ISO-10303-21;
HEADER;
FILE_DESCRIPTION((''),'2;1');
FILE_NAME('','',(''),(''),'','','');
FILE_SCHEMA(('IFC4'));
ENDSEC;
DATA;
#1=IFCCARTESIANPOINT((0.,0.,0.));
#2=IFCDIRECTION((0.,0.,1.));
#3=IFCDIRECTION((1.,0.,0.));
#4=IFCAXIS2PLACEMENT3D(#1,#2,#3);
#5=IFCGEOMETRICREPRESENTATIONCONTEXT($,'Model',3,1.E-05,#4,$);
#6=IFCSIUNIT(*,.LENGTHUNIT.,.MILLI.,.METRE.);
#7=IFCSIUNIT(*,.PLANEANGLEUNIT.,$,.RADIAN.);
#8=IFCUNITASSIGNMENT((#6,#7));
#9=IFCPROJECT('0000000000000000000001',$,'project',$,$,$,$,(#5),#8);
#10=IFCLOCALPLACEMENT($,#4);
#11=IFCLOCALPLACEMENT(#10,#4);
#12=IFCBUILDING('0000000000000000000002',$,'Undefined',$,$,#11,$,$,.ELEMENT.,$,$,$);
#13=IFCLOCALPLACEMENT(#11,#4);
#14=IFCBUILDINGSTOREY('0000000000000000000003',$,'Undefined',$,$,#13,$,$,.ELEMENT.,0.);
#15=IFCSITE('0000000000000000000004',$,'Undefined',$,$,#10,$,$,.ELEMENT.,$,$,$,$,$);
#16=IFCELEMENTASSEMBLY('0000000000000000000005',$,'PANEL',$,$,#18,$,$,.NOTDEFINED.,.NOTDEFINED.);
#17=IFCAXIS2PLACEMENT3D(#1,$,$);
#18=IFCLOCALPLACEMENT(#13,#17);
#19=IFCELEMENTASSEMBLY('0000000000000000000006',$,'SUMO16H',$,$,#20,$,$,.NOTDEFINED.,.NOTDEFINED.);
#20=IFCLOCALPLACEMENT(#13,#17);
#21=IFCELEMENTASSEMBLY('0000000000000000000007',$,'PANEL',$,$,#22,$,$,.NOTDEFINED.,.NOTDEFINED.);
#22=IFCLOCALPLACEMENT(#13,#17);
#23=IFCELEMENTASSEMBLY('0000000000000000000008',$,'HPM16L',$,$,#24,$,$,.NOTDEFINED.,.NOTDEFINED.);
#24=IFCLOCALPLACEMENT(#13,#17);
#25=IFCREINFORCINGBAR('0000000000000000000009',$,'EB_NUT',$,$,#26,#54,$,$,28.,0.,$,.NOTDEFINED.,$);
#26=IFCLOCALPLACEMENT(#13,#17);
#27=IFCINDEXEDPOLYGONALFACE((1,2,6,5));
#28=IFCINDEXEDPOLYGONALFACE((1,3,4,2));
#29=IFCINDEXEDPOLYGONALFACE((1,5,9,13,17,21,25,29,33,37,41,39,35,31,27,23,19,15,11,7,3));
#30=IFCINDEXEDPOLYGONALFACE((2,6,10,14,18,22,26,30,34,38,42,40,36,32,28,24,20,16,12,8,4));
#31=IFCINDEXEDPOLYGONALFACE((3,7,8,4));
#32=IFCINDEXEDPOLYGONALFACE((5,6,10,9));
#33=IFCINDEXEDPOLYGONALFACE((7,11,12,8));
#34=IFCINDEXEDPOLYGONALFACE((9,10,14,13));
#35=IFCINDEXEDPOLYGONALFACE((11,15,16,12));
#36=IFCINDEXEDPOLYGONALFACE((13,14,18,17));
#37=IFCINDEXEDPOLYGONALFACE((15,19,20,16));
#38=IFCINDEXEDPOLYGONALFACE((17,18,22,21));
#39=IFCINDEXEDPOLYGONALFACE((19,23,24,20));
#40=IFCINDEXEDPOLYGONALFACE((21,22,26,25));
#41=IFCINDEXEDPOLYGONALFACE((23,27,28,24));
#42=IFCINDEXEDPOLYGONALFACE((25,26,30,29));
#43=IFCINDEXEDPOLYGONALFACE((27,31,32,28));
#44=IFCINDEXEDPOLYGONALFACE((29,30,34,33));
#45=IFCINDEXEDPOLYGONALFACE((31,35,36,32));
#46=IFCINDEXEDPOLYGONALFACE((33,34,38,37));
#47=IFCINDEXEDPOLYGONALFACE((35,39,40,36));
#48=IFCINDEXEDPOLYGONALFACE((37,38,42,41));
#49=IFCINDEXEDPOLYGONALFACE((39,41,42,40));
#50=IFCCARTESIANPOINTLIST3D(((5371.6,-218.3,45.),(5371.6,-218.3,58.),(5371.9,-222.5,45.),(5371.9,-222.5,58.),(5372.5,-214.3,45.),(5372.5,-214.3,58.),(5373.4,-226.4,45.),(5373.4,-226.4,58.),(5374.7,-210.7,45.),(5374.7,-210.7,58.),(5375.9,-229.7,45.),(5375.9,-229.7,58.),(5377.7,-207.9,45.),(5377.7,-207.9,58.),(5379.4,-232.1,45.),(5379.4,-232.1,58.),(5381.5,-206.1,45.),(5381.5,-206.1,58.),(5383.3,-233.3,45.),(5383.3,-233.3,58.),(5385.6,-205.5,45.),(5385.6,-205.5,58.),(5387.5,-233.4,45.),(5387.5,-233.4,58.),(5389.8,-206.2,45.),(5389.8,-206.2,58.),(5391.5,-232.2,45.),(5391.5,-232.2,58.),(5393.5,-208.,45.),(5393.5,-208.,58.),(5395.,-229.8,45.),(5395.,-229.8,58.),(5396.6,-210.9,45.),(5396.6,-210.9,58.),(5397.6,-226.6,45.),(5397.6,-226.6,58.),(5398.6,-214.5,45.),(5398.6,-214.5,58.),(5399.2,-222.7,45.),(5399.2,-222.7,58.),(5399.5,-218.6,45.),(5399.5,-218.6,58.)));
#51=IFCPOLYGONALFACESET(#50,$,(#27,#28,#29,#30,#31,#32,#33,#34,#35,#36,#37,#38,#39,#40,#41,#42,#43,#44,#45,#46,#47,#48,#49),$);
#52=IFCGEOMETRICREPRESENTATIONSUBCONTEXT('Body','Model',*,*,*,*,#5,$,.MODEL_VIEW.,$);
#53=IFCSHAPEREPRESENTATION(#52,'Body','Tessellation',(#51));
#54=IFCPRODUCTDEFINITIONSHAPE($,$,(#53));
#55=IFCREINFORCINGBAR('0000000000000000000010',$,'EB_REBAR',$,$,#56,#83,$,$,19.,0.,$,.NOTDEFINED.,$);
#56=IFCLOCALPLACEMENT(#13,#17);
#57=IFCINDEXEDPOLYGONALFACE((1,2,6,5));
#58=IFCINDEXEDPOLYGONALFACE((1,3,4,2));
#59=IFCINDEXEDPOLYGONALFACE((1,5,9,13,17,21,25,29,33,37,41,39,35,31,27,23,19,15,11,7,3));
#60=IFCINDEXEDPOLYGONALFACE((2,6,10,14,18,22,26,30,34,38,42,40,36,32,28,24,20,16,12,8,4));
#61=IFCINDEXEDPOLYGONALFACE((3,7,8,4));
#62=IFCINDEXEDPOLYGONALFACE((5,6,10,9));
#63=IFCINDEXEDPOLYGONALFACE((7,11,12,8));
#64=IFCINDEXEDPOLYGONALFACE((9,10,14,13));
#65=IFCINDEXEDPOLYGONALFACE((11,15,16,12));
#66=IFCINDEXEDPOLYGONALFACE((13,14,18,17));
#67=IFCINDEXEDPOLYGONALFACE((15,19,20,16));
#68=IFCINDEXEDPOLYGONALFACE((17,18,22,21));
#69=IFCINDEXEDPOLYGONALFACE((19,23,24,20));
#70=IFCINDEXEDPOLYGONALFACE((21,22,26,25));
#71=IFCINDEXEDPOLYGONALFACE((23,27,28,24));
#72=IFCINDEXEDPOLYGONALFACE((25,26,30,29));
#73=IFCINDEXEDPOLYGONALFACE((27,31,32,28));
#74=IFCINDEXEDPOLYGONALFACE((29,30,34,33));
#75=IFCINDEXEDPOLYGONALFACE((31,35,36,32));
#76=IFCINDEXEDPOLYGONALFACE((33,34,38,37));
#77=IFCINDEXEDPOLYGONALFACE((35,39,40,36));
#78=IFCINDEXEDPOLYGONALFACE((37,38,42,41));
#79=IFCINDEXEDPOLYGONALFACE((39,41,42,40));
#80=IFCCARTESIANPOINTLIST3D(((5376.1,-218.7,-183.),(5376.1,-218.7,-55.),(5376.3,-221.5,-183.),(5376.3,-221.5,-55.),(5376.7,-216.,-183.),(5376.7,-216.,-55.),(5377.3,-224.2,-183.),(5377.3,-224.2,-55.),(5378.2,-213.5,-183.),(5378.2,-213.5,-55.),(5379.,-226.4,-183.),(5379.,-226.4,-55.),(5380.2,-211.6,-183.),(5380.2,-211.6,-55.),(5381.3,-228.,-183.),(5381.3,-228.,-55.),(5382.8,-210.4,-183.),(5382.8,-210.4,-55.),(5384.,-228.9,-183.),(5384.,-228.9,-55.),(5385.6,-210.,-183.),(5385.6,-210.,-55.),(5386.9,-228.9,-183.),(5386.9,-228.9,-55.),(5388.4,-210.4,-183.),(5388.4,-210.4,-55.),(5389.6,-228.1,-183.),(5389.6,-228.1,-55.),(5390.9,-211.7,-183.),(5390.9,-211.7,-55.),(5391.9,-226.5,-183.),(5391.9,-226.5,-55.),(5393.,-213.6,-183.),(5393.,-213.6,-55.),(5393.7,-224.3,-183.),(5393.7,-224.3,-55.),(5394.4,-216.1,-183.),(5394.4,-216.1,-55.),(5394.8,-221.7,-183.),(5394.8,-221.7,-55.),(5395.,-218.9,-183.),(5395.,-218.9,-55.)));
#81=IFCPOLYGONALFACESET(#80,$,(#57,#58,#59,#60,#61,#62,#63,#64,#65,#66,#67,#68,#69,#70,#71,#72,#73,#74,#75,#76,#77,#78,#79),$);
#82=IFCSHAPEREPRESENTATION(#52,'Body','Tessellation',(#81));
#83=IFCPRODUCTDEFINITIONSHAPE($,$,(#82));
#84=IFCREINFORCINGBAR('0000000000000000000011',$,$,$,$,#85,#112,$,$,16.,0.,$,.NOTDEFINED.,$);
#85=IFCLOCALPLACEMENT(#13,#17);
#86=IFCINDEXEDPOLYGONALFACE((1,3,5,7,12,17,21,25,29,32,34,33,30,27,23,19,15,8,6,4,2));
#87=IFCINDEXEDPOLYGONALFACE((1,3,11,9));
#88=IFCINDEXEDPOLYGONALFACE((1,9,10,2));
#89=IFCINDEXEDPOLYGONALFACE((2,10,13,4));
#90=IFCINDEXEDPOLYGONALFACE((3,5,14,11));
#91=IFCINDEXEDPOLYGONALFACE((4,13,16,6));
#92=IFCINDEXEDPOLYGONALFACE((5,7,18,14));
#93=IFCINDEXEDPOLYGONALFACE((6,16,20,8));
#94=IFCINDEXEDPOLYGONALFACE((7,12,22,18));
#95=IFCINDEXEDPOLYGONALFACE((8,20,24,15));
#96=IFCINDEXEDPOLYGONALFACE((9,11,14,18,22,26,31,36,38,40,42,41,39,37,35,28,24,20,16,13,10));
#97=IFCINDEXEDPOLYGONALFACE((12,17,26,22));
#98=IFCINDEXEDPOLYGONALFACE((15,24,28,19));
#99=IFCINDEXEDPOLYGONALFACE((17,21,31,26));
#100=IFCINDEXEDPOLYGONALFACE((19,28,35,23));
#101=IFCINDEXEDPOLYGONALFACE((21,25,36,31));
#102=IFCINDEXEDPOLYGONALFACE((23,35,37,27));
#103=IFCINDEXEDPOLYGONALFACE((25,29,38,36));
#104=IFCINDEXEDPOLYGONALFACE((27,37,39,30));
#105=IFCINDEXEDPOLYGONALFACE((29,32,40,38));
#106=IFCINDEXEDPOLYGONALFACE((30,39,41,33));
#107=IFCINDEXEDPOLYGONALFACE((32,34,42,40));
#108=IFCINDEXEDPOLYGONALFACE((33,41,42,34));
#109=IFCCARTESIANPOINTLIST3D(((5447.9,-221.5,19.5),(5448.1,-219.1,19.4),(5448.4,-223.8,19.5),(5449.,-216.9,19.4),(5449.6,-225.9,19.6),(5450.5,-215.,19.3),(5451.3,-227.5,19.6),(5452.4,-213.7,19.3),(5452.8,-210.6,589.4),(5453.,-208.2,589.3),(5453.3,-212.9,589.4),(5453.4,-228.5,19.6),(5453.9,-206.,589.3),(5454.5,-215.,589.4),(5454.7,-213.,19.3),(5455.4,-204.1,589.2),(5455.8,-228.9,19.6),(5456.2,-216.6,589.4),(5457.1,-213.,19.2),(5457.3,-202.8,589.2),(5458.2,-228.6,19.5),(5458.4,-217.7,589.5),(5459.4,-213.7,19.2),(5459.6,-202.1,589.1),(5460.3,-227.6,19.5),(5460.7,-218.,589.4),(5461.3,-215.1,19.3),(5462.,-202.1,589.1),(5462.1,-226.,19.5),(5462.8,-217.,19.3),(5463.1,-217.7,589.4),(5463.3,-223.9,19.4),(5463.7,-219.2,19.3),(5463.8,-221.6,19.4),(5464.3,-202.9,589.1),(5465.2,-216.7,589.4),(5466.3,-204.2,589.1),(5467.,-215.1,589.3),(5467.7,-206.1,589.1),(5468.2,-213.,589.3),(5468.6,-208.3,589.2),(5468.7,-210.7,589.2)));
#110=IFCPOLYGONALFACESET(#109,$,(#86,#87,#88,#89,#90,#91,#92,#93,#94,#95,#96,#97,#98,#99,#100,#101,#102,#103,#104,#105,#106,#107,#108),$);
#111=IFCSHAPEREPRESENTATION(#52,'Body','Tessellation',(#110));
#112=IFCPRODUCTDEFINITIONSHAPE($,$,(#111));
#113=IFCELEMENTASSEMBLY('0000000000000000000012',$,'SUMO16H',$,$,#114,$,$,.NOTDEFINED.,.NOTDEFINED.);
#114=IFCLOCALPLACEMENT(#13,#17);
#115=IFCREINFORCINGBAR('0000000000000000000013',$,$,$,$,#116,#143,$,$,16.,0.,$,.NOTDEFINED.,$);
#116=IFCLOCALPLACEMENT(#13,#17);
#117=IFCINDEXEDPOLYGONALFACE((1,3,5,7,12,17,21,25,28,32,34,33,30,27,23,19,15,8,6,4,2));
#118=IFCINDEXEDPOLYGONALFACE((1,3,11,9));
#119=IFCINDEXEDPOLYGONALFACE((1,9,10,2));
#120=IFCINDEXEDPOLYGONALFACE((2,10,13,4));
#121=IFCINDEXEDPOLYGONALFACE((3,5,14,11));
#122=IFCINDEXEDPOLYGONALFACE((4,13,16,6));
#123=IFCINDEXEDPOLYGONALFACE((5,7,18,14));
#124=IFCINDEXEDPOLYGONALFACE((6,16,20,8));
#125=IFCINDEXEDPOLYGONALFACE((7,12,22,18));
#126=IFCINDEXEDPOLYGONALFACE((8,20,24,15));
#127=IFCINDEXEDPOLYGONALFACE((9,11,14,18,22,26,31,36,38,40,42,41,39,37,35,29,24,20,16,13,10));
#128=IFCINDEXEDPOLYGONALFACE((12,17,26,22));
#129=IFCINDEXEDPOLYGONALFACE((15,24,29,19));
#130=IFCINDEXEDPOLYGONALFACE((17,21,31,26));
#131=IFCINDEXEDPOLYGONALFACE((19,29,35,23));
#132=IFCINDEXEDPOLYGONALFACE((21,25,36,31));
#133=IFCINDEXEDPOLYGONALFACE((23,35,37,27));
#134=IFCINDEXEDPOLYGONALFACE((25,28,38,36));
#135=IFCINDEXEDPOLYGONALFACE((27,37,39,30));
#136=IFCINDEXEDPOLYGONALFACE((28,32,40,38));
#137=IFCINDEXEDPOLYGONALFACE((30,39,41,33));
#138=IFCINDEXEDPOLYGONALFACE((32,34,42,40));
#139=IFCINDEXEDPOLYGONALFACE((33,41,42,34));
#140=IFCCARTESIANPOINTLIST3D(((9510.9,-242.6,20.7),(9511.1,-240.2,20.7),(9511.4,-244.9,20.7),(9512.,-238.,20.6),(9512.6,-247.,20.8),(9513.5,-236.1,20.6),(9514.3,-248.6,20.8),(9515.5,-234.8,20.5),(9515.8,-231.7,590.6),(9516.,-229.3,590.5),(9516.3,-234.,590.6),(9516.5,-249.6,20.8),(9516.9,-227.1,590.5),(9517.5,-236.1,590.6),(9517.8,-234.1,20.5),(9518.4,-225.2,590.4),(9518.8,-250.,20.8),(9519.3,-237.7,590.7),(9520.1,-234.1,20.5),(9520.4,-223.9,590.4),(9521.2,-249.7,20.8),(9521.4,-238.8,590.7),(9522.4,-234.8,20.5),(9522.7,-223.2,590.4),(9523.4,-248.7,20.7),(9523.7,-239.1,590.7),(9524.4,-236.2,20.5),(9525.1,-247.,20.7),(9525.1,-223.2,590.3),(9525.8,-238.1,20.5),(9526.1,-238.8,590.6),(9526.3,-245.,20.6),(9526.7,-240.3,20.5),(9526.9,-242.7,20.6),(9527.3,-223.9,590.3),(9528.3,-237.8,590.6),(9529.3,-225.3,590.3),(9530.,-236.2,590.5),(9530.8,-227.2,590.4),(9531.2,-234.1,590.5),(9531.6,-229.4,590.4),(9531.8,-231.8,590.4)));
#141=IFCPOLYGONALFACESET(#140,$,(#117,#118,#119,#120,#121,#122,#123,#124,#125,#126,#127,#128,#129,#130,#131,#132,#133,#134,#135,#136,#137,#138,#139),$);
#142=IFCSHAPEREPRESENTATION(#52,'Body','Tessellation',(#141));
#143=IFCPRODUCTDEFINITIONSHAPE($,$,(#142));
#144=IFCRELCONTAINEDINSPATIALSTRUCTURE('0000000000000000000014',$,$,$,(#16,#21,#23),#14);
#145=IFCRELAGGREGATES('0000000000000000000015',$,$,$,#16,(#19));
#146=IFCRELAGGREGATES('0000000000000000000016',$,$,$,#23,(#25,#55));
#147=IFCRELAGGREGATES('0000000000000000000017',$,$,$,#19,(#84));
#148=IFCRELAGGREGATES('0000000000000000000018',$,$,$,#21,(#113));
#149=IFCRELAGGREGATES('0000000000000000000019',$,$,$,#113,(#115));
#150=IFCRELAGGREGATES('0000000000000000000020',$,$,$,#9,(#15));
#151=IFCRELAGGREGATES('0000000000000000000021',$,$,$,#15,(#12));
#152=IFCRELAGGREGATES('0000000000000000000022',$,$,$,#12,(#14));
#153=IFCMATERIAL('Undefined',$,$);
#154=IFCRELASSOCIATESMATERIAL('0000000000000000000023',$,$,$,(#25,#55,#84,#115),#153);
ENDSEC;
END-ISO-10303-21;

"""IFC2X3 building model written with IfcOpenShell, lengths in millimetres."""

from ifc_helpers import new_model, entity, si_unit, frame, origin_with_axes, place, context, subcontext, project, spatial, source, transform, mapped, material, element, aggregate, save


model = new_model("IFC2X3")

# Units and contexts
model_context = context("Model", 3, precision=1e-05, world=origin_with_axes())
body_context = subcontext(model_context, "Body", "Model", "MODEL_VIEW")
ifc_project = project(units=[si_unit("LENGTHUNIT", "METRE", prefix="MILLI"), si_unit("PLANEANGLEUNIT", "RADIAN")], contexts=[model_context])

# Site, building, storey
site_placement = place(None, origin_with_axes())
site = spatial("IfcSite", under=ifc_project, at=site_placement, Name="Undefined", CompositionType="ELEMENT")
building_placement = place(site_placement, origin_with_axes())
building = spatial("IfcBuilding", under=site, at=building_placement, Name="Undefined", CompositionType="ELEMENT")
storey_placement = place(building_placement, origin_with_axes())
storey = spatial("IfcBuildingStorey", under=building, at=storey_placement, Name="Undefined", CompositionType="ELEMENT", Elevation=0.0)

# Element assemblies
assembly_1_placement = place(storey_placement, origin_with_axes())
assembly_1 = element("IfcElementAssembly", 1, at=assembly_1_placement, inside=storey, Name="PANEL", AssemblyPlace="NOTDEFINED", PredefinedType="NOTDEFINED")
assembly_2_placement = place(assembly_1_placement, origin_with_axes())
assembly_2 = element("IfcElementAssembly", 2, at=assembly_2_placement, Name="SUMO16H", AssemblyPlace="NOTDEFINED", PredefinedType="NOTDEFINED")

# Element assembly
assembly_3_placement = place(storey_placement, origin_with_axes())
assembly_3 = element("IfcElementAssembly", 3, at=assembly_3_placement, inside=storey, Name="PANEL", AssemblyPlace="NOTDEFINED", PredefinedType="NOTDEFINED")

aggregate(assembly_1, [assembly_2])

# Element assembly, reinforcing bars
assembly_4_placement = place(storey_placement, origin_with_axes())
assembly_4 = element("IfcElementAssembly", 4, at=assembly_4_placement, inside=storey, Name="HPM16L", AssemblyPlace="NOTDEFINED", PredefinedType="NOTDEFINED")
ifc_material_1 = material(Name="Undefined")
shared_shape_1 = source(origin_with_axes(), body_context, "Body", "AdvancedSweptSolid", [
    entity("IfcSweptDiskSolid", entity("IfcTrimmedCurve", entity("IfcLine", entity("IfcCartesianPoint", [0.0, 0.0, 0.0]), entity("IfcVector", entity("IfcDirection", [1.0, 0.0, 0.0]), 1.0)), [entity("IfcParameterValue", 0.0)], [entity("IfcParameterValue", 13.0)], True, "PARAMETER"), 14.0, None, 0.0, 13.0),
])
reinforcing_bar_1_placement = place(assembly_4_placement, frame((5385.5, -219.5, 58.0), z_axis=(0.008166, 0.999967, 0.0), x_axis=(0.0, 0.0, -1.0)))
reinforcing_bar_1 = element("IfcReinforcingBar", 5, at=reinforcing_bar_1_placement, material=ifc_material_1, Name="EB_NUT", BarRole="NOTDEFINED", CrossSectionArea=0.0, NominalDiameter=28.0, context=body_context, shape_type="MappedRepresentation", body=[
    mapped(shared_shape_1, transform((0.0, 0.0, 0.0))),
])
shared_shape_2 = source(origin_with_axes(), body_context, "Body", "AdvancedSweptSolid", [
    entity("IfcSweptDiskSolid", entity("IfcTrimmedCurve", entity("IfcLine", entity("IfcCartesianPoint", [0.0, 0.0, 0.0]), entity("IfcVector", entity("IfcDirection", [1.0, 0.0, 0.0]), 1.0)), [entity("IfcParameterValue", 0.0)], [entity("IfcParameterValue", 128.0)], True, "PARAMETER"), 9.5, None, 0.0, 128.0),
])
reinforcing_bar_2_placement = place(assembly_4_placement, frame((5385.5, -219.5, -55.0), z_axis=(0.008166, 0.999967, 0.0), x_axis=(0.0, 0.0, -1.0)))
reinforcing_bar_2 = element("IfcReinforcingBar", 6, at=reinforcing_bar_2_placement, material=ifc_material_1, Name="EB_REBAR", BarRole="NOTDEFINED", CrossSectionArea=0.0, NominalDiameter=19.0, context=body_context, shape_type="MappedRepresentation", body=[
    mapped(shared_shape_2, transform((0.0, 0.0, 0.0))),
])
aggregate(assembly_4, [reinforcing_bar_1, reinforcing_bar_2])

# Reinforcing bar
shared_shape_3 = source(origin_with_axes(), body_context, "Body", "AdvancedSweptSolid", [
    entity("IfcSweptDiskSolid", entity("IfcTrimmedCurve", entity("IfcLine", entity("IfcCartesianPoint", [0.0, 0.0, 0.0]), entity("IfcVector", entity("IfcDirection", [1.0, 0.0, 0.0]), 1.0)), [entity("IfcParameterValue", 0.0)], [entity("IfcParameterValue", 570.0)], True, "PARAMETER"), 8.0, None, 0.0, 570.0),
])
reinforcing_bar_3_placement = place(assembly_2_placement, frame((5455.9, -220.9, 19.4), z_axis=(-0.006955, -0.999792, 0.019153), x_axis=(0.008618, 0.019092, 0.999781)))
reinforcing_bar_3 = element("IfcReinforcingBar", 7, at=reinforcing_bar_3_placement, material=ifc_material_1, BarRole="NOTDEFINED", CrossSectionArea=0.0, NominalDiameter=16.0, context=body_context, shape_type="MappedRepresentation", body=[
    mapped(shared_shape_3, transform((0.0, 0.0, 0.0))),
])
aggregate(assembly_2, [reinforcing_bar_3])

# Element assembly
assembly_5_placement = place(assembly_3_placement, origin_with_axes())
assembly_5 = element("IfcElementAssembly", 8, at=assembly_5_placement, Name="SUMO16H", AssemblyPlace="NOTDEFINED", PredefinedType="NOTDEFINED")
aggregate(assembly_3, [assembly_5])

# Reinforcing bar
shared_shape_4 = source(origin_with_axes(), body_context, "Body", "AdvancedSweptSolid", [
    entity("IfcSweptDiskSolid", entity("IfcTrimmedCurve", entity("IfcLine", entity("IfcCartesianPoint", [0.0, 0.0, 0.0]), entity("IfcVector", entity("IfcDirection", [1.0, 0.0, 0.0]), 1.0)), [entity("IfcParameterValue", 0.0)], [entity("IfcParameterValue", 570.0)], True, "PARAMETER"), 8.0, None, 0.0, 570.0),
])
reinforcing_bar_4_placement = place(assembly_5_placement, frame((9518.9, -242.0, 20.6), z_axis=(-0.006955, -0.999792, 0.019153), x_axis=(0.008618, 0.019092, 0.999781)))
reinforcing_bar_4 = element("IfcReinforcingBar", 9, at=reinforcing_bar_4_placement, material=ifc_material_1, BarRole="NOTDEFINED", CrossSectionArea=0.0, NominalDiameter=16.0, context=body_context, shape_type="MappedRepresentation", body=[
    mapped(shared_shape_4, transform((0.0, 0.0, 0.0))),
])
aggregate(assembly_5, [reinforcing_bar_4])

save(model, "model.ifc")
